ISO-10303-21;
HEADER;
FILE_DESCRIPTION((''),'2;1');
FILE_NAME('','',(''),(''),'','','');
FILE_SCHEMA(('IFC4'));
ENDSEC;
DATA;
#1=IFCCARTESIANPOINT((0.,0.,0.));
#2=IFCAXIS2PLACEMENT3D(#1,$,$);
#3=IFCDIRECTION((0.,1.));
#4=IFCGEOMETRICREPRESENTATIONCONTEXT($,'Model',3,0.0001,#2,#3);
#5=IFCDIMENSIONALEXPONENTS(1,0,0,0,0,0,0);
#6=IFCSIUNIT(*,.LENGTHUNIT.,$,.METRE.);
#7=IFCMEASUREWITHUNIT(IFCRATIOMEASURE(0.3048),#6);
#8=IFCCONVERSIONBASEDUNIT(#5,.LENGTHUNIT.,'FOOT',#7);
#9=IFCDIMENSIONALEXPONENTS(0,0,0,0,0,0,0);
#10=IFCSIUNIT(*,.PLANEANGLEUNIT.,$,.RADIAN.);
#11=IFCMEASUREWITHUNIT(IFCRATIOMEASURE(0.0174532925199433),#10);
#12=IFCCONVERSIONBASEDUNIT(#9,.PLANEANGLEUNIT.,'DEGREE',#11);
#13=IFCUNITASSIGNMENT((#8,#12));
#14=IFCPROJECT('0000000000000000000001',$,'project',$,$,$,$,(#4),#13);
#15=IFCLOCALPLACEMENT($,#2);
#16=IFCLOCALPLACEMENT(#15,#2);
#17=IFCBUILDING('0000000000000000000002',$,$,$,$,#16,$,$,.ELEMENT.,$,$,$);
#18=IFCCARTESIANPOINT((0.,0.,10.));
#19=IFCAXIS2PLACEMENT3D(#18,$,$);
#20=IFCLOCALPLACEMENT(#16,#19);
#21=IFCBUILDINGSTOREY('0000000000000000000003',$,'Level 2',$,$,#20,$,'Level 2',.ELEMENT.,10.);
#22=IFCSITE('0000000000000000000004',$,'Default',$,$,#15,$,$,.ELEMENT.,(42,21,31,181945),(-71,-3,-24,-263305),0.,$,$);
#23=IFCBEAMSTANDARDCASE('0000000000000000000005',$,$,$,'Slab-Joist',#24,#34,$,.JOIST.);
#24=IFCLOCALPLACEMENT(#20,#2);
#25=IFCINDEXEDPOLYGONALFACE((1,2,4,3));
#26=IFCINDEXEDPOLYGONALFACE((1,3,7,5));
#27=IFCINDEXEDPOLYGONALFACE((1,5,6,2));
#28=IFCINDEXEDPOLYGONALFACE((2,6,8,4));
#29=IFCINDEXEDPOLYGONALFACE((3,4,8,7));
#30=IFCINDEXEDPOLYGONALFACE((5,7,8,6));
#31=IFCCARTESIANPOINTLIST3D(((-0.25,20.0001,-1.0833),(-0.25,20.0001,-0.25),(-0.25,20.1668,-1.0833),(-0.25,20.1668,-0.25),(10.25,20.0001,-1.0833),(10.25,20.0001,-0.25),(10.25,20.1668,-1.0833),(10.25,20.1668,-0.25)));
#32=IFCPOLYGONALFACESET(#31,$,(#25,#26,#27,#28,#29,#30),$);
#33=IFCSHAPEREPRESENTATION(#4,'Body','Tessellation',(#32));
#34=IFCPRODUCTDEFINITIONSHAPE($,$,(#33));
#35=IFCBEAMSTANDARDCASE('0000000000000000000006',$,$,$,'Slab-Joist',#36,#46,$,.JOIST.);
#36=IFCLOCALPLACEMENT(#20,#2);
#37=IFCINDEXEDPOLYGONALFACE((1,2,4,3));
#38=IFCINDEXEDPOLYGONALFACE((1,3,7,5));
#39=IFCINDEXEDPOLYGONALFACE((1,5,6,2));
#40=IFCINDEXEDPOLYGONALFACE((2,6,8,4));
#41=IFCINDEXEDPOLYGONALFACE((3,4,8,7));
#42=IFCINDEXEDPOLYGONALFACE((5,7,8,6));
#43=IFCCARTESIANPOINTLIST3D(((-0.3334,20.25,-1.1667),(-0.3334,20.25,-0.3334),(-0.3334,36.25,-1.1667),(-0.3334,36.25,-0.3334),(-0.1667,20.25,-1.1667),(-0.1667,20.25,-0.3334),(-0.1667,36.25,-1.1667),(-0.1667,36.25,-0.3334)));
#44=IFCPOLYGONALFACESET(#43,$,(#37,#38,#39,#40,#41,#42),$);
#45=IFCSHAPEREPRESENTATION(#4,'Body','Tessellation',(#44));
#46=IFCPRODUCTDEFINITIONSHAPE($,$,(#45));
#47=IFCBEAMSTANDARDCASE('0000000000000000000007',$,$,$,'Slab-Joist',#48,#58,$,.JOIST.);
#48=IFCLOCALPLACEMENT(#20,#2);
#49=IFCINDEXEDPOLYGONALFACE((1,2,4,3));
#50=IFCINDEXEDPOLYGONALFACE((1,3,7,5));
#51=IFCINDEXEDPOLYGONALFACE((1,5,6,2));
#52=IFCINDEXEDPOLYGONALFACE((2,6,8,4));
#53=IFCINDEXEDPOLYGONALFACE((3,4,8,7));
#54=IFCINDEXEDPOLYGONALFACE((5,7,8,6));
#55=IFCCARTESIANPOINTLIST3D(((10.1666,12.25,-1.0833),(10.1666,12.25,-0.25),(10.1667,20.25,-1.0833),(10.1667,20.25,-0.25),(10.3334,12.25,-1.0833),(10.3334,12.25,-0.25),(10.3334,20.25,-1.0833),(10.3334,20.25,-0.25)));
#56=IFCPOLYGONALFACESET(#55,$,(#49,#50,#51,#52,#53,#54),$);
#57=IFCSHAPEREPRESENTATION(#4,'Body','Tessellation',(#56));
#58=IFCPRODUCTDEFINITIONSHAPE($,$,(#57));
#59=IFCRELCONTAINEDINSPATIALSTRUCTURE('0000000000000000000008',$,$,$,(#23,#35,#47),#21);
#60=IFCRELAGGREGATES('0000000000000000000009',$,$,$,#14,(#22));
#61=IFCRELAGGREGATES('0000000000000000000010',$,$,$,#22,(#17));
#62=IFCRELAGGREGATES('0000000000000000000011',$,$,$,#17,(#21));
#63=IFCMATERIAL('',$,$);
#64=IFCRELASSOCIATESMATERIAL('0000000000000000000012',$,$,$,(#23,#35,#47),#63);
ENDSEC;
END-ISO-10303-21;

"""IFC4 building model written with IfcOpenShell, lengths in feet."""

from ifc_helpers import new_model, entity, si_unit, converted_unit, direction, frame, origin, origin_with_axes, place, context, project, spatial, rectangle, extrude, material, element, save


model = new_model("IFC4")

# Units and contexts
model_context = context("Model", 3, precision=0.0001, world=origin(), true_north=direction((0.0, 1.0)))
ifc_project = project(units=[converted_unit("LENGTHUNIT", "FOOT", entity("IfcRatioMeasure", 0.3048), si_unit("LENGTHUNIT", "METRE"), dimensions=[1, 0, 0, 0, 0, 0, 0]), converted_unit("PLANEANGLEUNIT", "DEGREE", entity("IfcRatioMeasure", 0.0174532925199433), si_unit("PLANEANGLEUNIT", "RADIAN"), dimensions=[0, 0, 0, 0, 0, 0, 0])], contexts=[model_context])

# Site, building, storey
site_placement = place(None, origin())
site = spatial("IfcSite", under=ifc_project, at=site_placement, Name="Default", CompositionType="ELEMENT", RefLatitude=(42, 21, 31, 181945), RefLongitude=(-71, -3, -24, -263305), RefElevation=0.0)
building_placement = place(site_placement, origin())
building = spatial("IfcBuilding", under=site, at=building_placement, CompositionType="ELEMENT")
storey_placement = place(building_placement, frame((0.0, 0.0, 10.0)))
storey = spatial("IfcBuildingStorey", under=building, at=storey_placement, Name="Level 2", LongName="Level 2", CompositionType="ELEMENT", Elevation=10.0)

# Beams
ifc_material = material(Name="")
placement_1 = place(storey_placement, frame((-0.25, -0.25, 0.0), z_axis=(0.0, 0.0, 1.0), x_axis=(1.0, 0.0, 0.0)))
beam_1_placement = place(placement_1, frame((0.0, 20.3334, -0.6667), z_axis=(1.0, 0.0, 0.0), x_axis=(0.0, 1.0, 0.0)))
element("IfcBeamStandardCase", 1, at=beam_1_placement, inside=storey, material=ifc_material, ObjectType="Slab-Joist", PredefinedType="JOIST", context=model_context, shape_type="SweptSolid", body=[
    extrude(rectangle(XDim=0.1667, YDim=0.8333), origin_with_axes(), (0.0, 0.0, 1.0), 10.5),
])
placement_2 = place(storey_placement, frame((-0.25, 20.25, 0.0), z_axis=(0.0, 0.0, 1.0), x_axis=(1.0, 0.0, 0.0)))
beam_2_placement = place(placement_2, frame((0.0, 0.0, -0.75), z_axis=(0.0, 1.0, 0.0), x_axis=(-1.0, 0.0, 0.0)))
element("IfcBeamStandardCase", 2, at=beam_2_placement, inside=storey, material=ifc_material, ObjectType="Slab-Joist", PredefinedType="JOIST", context=model_context, shape_type="SweptSolid", body=[
    extrude(rectangle(XDim=0.1667, YDim=0.8333), origin_with_axes(), (0.0, 0.0, 1.0), 16.0),
])
placement_3 = place(storey_placement, frame((10.25, 12.25, 0.0), z_axis=(0.0, 0.0, 1.0), x_axis=(1.0, 0.0, 0.0)))
beam_3_placement = place(placement_3, frame((0.0, 0.0, -0.6667), z_axis=(0.0, 1.0, 0.0), x_axis=(-1.0, 0.0, 0.0)))
element("IfcBeamStandardCase", 3, at=beam_3_placement, inside=storey, material=ifc_material, ObjectType="Slab-Joist", PredefinedType="JOIST", context=model_context, shape_type="SweptSolid", body=[
    extrude(rectangle(XDim=0.1667, YDim=0.8333), origin_with_axes(), (0.0, 0.0, 1.0), 8.0),
])

save(model, "model.ifc")
